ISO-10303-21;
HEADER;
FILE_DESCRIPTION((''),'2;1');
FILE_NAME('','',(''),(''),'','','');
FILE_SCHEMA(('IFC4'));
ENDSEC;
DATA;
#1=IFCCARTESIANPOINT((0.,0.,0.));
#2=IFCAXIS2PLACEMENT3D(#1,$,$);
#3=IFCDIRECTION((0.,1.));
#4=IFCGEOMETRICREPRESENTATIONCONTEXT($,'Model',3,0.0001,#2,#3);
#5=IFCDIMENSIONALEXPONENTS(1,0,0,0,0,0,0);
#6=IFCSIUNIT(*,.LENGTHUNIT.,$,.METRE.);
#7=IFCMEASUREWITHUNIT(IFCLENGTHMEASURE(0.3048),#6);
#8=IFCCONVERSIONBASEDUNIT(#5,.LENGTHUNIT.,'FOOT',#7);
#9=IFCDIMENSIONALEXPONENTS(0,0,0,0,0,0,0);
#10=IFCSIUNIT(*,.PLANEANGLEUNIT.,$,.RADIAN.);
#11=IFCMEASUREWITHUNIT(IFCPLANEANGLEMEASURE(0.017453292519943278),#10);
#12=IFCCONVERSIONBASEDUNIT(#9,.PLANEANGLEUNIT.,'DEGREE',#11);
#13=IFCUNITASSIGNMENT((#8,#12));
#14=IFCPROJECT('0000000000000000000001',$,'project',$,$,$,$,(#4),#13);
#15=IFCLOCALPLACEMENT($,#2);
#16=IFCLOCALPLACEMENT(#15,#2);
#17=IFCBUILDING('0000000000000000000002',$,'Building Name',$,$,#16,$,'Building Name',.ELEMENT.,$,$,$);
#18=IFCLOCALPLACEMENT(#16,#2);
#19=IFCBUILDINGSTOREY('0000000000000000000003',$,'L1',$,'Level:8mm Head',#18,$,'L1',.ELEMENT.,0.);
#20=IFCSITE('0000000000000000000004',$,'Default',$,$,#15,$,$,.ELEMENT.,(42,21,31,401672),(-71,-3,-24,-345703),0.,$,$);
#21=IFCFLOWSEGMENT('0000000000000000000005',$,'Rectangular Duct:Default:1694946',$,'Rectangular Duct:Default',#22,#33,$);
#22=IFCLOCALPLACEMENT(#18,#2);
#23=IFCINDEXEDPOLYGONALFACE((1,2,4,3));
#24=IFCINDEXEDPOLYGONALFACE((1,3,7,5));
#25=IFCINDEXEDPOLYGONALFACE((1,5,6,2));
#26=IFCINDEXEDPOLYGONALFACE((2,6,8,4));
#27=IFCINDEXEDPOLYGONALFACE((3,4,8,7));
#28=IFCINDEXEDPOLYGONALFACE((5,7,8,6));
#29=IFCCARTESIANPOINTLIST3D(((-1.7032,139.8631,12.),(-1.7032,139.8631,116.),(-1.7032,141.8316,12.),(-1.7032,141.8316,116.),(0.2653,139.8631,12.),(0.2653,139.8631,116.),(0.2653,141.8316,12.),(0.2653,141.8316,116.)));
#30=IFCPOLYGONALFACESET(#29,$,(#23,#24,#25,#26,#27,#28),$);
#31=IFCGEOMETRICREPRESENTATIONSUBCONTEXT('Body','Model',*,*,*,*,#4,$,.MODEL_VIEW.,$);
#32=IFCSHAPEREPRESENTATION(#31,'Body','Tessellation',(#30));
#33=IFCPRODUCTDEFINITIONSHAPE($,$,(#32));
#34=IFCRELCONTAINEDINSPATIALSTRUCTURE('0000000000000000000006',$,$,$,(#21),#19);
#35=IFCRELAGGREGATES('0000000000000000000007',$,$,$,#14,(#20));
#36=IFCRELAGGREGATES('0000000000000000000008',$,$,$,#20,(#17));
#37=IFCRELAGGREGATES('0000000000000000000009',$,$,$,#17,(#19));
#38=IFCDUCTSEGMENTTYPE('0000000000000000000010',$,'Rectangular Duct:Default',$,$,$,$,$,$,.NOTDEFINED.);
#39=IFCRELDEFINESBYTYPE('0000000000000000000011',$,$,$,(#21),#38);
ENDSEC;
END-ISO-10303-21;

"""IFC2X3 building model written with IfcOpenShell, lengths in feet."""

from ifc_helpers import new_model, entity, si_unit, converted_unit, direction, frame, origin, origin_2d_with_axis, place, context, subcontext, project, spatial, rectangle, extrude, type_object, element, save


model = new_model("IFC2X3")

# Units and contexts
model_context = context("Model", 3, precision=0.0001, world=origin(), true_north=direction((0.0, 1.0)))
body_context = subcontext(model_context, "Body", "Model", "MODEL_VIEW")
ifc_project = project(units=[converted_unit("LENGTHUNIT", "FOOT", entity("IfcLengthMeasure", 0.3048), si_unit("LENGTHUNIT", "METRE"), dimensions=[1, 0, 0, 0, 0, 0, 0]), converted_unit("PLANEANGLEUNIT", "DEGREE", entity("IfcPlaneAngleMeasure", 0.017453292519943278), si_unit("PLANEANGLEUNIT", "RADIAN"), dimensions=[0, 0, 0, 0, 0, 0, 0])], contexts=[model_context])

# Site, building, storey
site_placement = place(None, origin())
site = spatial("IfcSite", under=ifc_project, at=site_placement, Name="Default", CompositionType="ELEMENT", RefLatitude=(42, 21, 31, 401672), RefLongitude=(-71, -3, -24, -345703), RefElevation=0.0)
building_placement = place(site_placement, origin())
building = spatial("IfcBuilding", under=site, at=building_placement, Name="Building Name", LongName="Building Name", CompositionType="ELEMENT")
storey_placement = place(building_placement, origin())
storey = spatial("IfcBuildingStorey", under=building, at=storey_placement, Name="L1", ObjectType="Level:8mm Head", LongName="L1", CompositionType="ELEMENT", Elevation=0.0)

# Flow segment
duct_segment_type = type_object("IfcDuctSegmentType", Name="Rectangular Duct:Default", PredefinedType="NOTDEFINED")
flow_segment_placement = place(storey_placement, origin())
element("IfcFlowSegment", 1, at=flow_segment_placement, inside=storey, type_object=duct_segment_type, Name="Rectangular Duct:Default:1694946", ObjectType="Rectangular Duct:Default", context=body_context, shape_type="SweptSolid", body=[
    extrude(rectangle(XDim=1.9685, YDim=1.9685, at=origin_2d_with_axis()), frame((-0.719, 140.8473, 12.0)), (0.0, 0.0, 1.0), 104.0),
])

save(model, "model.ifc")
